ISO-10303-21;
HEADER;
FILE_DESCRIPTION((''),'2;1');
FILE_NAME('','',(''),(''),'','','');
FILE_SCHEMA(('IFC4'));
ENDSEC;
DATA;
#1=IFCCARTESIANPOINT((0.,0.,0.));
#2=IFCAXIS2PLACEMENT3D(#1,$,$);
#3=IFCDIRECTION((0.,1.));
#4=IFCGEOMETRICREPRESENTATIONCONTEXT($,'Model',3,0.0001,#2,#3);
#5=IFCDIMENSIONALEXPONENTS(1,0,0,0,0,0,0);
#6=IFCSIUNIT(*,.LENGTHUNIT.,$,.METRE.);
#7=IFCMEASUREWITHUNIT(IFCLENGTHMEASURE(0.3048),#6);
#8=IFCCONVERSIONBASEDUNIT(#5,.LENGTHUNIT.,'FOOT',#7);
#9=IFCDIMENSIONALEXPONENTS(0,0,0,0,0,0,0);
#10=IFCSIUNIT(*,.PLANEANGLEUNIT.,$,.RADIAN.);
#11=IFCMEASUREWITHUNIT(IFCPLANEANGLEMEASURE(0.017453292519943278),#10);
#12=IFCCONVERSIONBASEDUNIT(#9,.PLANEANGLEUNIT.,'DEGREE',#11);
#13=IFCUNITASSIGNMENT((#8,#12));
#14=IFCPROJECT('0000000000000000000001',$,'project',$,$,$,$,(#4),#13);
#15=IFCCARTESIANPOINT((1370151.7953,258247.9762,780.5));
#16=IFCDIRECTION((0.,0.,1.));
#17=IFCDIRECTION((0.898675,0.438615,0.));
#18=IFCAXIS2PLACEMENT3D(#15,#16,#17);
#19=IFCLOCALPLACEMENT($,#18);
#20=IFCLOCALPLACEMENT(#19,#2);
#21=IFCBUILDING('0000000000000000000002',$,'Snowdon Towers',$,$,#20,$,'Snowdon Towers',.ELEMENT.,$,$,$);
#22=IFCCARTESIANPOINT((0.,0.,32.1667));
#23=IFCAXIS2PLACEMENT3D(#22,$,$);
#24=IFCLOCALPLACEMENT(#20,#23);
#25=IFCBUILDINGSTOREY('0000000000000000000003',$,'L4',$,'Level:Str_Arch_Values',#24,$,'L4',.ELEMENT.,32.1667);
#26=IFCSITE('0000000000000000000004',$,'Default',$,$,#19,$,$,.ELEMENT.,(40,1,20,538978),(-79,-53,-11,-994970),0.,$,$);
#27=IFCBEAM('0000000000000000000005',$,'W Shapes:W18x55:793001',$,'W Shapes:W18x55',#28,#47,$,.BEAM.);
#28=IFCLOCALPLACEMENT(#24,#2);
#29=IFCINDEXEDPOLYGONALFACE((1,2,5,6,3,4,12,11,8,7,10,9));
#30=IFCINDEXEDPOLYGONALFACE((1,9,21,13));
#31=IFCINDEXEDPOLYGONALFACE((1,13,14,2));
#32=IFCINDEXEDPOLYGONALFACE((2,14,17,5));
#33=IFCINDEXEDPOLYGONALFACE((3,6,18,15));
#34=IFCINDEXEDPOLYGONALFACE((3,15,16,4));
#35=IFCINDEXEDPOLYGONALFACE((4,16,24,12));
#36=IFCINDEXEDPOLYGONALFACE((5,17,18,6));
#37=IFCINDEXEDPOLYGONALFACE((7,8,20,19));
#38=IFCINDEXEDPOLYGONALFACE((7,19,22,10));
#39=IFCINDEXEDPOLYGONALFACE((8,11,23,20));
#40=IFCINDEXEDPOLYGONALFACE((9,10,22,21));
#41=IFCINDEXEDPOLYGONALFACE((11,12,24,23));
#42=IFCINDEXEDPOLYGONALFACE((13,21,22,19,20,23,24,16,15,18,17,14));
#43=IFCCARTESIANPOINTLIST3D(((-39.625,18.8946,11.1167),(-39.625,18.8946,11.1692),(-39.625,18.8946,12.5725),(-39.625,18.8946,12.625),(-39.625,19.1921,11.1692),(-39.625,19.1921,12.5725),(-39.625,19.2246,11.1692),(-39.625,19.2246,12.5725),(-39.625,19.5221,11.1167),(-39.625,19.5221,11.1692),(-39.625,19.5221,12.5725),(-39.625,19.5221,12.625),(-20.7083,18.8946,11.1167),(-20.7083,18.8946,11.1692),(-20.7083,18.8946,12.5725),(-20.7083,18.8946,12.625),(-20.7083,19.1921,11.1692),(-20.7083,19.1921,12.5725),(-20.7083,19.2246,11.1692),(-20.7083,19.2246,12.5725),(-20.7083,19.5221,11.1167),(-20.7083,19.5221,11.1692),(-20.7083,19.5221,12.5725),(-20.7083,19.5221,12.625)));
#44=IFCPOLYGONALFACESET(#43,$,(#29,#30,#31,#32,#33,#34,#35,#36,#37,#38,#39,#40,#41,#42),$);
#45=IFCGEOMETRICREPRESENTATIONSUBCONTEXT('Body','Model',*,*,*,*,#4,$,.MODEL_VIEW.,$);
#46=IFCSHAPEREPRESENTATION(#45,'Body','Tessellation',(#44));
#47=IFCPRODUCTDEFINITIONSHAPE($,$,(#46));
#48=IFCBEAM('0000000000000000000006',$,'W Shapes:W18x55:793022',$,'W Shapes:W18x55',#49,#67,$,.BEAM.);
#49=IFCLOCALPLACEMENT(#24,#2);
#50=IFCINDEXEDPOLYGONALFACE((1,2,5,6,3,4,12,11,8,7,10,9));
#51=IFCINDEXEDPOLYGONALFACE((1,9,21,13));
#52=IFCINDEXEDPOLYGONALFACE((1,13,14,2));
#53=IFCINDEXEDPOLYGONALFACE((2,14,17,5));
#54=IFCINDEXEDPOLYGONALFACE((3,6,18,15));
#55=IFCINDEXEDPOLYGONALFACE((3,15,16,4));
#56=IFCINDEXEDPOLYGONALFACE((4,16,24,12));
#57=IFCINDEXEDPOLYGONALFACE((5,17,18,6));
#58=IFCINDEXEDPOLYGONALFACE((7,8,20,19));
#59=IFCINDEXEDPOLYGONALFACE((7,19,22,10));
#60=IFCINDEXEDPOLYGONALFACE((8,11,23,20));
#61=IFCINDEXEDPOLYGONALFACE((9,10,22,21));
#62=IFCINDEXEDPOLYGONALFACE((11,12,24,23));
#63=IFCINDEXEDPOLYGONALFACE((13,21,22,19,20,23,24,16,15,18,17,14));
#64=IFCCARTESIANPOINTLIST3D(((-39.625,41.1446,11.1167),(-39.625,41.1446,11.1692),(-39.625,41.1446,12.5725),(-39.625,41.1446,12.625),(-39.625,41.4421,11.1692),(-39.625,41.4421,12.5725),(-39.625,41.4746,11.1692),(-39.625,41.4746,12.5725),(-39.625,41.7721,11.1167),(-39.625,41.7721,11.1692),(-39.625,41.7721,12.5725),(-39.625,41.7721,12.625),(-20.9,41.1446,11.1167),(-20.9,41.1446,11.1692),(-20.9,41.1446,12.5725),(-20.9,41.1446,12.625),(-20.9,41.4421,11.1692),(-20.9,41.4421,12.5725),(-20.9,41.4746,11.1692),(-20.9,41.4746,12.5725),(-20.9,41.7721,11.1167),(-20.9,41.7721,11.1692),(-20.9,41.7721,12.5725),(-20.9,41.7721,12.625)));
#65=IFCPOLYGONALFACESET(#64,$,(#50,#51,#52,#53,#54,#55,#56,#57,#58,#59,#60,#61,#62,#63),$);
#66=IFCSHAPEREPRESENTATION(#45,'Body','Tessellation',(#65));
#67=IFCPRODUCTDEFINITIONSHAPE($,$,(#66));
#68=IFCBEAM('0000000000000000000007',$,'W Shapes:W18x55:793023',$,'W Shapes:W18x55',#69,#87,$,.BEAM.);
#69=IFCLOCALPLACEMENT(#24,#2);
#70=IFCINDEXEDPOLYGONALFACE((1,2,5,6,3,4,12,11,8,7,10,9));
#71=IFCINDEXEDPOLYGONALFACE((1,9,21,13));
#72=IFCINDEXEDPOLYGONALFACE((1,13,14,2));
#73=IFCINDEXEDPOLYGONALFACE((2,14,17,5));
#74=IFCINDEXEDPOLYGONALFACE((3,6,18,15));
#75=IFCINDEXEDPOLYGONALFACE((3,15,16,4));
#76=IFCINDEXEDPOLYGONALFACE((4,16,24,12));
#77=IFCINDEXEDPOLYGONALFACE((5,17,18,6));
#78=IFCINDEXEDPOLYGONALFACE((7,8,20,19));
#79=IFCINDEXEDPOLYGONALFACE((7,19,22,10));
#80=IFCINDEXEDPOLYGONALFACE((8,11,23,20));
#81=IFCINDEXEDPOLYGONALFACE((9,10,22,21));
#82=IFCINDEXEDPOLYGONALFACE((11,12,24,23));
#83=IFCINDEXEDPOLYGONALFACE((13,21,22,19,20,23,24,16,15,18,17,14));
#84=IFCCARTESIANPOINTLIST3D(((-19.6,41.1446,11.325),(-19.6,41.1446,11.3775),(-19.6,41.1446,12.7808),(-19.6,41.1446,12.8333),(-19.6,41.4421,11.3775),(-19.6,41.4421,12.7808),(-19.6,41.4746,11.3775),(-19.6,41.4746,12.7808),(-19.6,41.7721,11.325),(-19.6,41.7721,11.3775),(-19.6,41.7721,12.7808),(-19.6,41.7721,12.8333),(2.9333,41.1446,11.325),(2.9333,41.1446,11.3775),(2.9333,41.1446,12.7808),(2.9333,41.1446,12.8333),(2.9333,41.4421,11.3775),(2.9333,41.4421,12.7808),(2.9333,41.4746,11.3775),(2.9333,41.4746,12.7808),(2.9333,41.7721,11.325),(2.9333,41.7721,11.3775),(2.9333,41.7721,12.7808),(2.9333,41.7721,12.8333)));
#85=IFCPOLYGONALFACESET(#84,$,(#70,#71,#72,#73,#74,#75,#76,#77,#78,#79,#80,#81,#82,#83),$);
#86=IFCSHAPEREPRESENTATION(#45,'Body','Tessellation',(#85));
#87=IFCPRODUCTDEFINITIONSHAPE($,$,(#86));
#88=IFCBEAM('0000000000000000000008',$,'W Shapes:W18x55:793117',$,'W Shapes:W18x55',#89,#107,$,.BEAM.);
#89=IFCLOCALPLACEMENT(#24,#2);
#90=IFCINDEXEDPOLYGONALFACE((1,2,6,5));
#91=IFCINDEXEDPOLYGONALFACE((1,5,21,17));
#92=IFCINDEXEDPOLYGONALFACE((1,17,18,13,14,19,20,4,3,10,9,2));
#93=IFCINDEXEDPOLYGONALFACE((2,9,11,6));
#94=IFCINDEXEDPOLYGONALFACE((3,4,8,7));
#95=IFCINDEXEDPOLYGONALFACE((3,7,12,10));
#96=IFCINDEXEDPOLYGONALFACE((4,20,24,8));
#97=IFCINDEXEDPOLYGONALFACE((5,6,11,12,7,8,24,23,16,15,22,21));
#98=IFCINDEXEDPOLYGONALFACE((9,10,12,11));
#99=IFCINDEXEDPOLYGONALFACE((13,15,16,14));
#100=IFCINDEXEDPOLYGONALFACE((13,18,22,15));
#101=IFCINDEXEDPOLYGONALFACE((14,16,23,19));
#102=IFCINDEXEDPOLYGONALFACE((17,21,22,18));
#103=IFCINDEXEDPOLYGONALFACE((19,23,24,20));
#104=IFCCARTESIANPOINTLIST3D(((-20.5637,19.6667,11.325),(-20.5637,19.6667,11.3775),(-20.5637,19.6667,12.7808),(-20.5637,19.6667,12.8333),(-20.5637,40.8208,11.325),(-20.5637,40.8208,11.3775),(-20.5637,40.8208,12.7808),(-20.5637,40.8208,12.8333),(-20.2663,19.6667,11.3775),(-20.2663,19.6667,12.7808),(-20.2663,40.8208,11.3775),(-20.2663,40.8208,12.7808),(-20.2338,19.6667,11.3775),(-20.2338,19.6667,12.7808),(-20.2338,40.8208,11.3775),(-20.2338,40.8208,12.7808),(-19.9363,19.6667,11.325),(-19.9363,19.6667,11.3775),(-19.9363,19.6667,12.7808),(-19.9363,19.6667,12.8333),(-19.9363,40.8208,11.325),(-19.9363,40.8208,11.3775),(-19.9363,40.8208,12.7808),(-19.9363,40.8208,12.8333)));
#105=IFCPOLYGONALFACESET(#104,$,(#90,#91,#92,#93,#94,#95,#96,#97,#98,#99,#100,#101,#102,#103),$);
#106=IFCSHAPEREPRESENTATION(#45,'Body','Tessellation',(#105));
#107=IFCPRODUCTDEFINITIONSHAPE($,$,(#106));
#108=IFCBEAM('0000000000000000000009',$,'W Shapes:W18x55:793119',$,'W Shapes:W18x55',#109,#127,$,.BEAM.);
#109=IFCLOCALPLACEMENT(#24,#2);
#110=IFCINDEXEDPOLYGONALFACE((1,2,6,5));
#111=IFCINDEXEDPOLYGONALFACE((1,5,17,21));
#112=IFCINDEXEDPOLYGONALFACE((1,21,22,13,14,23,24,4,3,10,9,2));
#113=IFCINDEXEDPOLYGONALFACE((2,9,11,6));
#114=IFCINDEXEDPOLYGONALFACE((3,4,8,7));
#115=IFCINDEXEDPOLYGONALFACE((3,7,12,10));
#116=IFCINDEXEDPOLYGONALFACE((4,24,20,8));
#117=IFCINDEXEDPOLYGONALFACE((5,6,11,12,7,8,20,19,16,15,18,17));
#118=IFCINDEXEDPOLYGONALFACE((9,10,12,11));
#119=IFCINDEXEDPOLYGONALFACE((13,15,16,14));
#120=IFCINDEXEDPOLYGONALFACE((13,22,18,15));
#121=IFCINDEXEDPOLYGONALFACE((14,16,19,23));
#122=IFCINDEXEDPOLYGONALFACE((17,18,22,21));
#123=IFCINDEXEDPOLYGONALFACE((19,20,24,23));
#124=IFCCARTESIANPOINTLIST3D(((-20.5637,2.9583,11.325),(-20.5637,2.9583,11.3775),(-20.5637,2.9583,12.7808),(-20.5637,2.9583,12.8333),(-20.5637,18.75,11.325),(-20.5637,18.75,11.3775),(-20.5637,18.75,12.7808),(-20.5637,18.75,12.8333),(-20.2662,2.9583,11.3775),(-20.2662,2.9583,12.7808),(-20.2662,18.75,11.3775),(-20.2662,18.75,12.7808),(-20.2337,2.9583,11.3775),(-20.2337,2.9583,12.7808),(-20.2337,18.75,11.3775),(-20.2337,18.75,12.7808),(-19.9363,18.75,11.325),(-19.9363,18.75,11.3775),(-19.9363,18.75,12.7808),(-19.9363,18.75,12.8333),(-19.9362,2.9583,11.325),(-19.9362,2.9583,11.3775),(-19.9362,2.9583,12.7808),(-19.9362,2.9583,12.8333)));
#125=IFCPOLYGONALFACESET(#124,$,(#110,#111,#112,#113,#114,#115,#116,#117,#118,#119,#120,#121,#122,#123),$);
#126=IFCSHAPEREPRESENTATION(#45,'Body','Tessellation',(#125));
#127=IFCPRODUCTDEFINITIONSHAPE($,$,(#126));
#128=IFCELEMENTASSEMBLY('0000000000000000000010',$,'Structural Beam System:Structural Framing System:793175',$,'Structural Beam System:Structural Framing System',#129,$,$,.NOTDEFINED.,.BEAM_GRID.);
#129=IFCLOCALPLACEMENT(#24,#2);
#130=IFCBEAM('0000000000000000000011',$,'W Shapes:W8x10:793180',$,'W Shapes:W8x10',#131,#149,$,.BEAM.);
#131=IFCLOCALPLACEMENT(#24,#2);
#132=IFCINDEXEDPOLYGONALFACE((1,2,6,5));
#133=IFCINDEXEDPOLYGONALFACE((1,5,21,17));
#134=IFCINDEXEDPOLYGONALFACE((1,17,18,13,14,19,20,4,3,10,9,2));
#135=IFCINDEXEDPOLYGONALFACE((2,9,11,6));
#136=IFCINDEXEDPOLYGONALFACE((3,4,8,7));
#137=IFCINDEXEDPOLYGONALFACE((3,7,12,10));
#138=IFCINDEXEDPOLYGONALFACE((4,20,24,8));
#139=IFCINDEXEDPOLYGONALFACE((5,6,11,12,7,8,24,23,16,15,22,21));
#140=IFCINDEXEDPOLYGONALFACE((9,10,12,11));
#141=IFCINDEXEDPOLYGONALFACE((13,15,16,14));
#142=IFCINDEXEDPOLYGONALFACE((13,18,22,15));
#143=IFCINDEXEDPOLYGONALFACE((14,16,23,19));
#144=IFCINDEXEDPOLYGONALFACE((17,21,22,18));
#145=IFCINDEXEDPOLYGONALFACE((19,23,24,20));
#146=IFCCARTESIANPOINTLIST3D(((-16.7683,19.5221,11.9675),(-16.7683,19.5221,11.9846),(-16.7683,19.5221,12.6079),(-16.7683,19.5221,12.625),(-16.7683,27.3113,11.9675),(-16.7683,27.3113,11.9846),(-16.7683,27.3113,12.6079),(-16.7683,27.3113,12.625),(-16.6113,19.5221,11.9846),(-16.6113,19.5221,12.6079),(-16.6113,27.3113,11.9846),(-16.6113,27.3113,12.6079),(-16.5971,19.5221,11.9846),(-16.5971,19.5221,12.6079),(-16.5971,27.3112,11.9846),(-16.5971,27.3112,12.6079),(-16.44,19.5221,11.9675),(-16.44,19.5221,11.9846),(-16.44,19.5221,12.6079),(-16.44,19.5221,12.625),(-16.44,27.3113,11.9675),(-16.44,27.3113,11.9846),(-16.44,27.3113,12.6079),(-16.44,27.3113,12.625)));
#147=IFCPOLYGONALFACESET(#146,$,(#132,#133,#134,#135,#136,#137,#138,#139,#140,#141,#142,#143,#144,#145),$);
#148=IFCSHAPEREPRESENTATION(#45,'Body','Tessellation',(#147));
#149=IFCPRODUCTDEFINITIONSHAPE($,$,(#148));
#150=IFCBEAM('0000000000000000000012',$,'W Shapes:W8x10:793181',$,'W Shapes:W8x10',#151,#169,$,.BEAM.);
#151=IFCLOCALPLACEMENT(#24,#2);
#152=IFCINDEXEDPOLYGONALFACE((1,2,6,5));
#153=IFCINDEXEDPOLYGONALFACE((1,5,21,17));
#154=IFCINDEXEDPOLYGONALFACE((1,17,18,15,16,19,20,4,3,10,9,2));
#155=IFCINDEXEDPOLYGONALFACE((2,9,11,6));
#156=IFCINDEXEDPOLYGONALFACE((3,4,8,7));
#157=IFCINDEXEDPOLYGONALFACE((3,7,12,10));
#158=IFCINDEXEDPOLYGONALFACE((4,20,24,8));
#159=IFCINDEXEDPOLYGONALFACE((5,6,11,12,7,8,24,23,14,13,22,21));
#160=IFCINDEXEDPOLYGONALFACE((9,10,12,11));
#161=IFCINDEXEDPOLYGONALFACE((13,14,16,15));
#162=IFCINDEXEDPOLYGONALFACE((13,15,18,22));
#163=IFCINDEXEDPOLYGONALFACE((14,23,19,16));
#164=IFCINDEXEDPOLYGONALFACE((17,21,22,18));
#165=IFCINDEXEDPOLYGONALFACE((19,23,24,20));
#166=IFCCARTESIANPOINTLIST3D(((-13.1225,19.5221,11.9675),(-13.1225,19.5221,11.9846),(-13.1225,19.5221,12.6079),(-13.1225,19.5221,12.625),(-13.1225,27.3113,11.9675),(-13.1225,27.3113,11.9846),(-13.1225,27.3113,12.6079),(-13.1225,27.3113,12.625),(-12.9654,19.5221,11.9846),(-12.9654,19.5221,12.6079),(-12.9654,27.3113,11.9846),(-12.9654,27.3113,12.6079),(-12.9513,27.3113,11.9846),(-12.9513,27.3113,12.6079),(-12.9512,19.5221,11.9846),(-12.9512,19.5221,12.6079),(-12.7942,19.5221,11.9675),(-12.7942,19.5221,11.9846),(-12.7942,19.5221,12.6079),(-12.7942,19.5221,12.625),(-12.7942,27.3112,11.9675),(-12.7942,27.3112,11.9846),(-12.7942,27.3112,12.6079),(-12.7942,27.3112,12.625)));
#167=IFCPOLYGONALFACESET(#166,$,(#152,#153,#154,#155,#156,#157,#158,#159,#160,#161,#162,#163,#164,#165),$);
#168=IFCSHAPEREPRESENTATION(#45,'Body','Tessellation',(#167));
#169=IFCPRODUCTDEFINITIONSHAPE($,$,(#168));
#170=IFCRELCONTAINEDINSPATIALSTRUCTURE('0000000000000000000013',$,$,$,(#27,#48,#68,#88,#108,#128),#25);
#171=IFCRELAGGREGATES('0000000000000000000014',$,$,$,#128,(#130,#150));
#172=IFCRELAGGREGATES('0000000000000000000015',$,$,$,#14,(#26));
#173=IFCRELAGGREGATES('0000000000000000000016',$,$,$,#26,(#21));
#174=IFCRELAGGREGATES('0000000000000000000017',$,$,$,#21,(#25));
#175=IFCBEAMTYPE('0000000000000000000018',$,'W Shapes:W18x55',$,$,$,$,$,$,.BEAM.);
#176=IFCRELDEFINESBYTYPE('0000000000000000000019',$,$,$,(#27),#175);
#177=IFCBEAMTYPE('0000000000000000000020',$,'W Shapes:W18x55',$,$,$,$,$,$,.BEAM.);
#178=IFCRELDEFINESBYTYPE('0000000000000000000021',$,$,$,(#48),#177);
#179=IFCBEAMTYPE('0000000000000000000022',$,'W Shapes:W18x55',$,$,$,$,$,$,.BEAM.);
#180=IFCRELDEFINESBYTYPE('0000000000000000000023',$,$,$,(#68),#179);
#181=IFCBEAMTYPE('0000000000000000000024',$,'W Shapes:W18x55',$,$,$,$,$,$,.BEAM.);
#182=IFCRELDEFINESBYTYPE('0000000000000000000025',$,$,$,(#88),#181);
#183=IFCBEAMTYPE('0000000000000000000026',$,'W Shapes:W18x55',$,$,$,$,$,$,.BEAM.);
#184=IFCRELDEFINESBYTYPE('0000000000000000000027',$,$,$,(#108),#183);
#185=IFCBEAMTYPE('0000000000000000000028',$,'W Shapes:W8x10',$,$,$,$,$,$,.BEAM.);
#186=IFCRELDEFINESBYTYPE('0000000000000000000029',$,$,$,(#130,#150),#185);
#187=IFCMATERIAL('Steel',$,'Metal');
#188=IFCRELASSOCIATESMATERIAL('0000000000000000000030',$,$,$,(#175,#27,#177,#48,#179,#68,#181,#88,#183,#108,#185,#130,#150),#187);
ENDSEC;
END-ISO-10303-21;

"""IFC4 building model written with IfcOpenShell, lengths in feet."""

from ifc_helpers import new_model, entity, si_unit, converted_unit, direction, frame, origin, place, context, subcontext, project, spatial, indexed_curve, outline, extrude, source, transform, mapped, material, type_object, type_shapes, element, aggregate, save


model = new_model("IFC4")

# Units and contexts
model_context = context("Model", 3, precision=0.0001, world=origin(), true_north=direction((0.0, 1.0)))
body_context = subcontext(model_context, "Body", "Model", "MODEL_VIEW")
ifc_project = project(units=[converted_unit("LENGTHUNIT", "FOOT", entity("IfcLengthMeasure", 0.3048), si_unit("LENGTHUNIT", "METRE"), dimensions=[1, 0, 0, 0, 0, 0, 0]), converted_unit("PLANEANGLEUNIT", "DEGREE", entity("IfcPlaneAngleMeasure", 0.017453292519943278), si_unit("PLANEANGLEUNIT", "RADIAN"), dimensions=[0, 0, 0, 0, 0, 0, 0])], contexts=[model_context])

# Site, building, storey
site_placement = place(None, frame((1370151.7953, 258247.9762, 780.5), z_axis=(0.0, 0.0, 1.0), x_axis=(0.898675, 0.438615, 0.0)))
site = spatial("IfcSite", under=ifc_project, at=site_placement, Name="Default", CompositionType="ELEMENT", RefLatitude=(40, 1, 20, 538978), RefLongitude=(-79, -53, -11, -994970), RefElevation=0.0)
building_placement = place(site_placement, origin())
building = spatial("IfcBuilding", under=site, at=building_placement, Name="Snowdon Towers", LongName="Snowdon Towers", CompositionType="ELEMENT")
storey_placement = place(building_placement, frame((0.0, 0.0, 32.1667)))
storey = spatial("IfcBuildingStorey", under=building, at=storey_placement, Name="L4", ObjectType="Level:Str_Arch_Values", LongName="L4", CompositionType="ELEMENT", Elevation=32.1667)

# Shared definitions
ifc_material = material(Name="Steel", Category="Metal")

# Beams
beam_type_1 = type_object("IfcBeamType", Name="W Shapes:W18x55", PredefinedType="BEAM", material=ifc_material)
shared_shape_1 = source(origin(), body_context, "Body", "SweptSolid", [
    extrude(outline(indexed_curve([(-0.3138, -0.7017), (-0.3138, -0.7542), (0.3138, -0.7542), (0.3138, -0.7017), (0.0162, -0.7017), (0.0162, 0.7017), (0.3138, 0.7017), (0.3138, 0.7542), (-0.3137, 0.7542), (-0.3137, 0.7017), (-0.0163, 0.7017), (-0.0163, -0.7017), (-0.3138, -0.7017)], self_intersect=False)), frame((-9.5625, 0.0, 0.0), z_axis=(-1.0, 0.0, 0.0), x_axis=(0.0, -1.0, 0.0)), (0.0, 0.0, -1.0), 18.9167),
])
type_shapes(beam_type_1, [shared_shape_1])
beam_1_placement = place(storey_placement, frame((-30.0625, 19.2083, 11.8708)))
element("IfcBeam", 1, at=beam_1_placement, inside=storey, type_object=beam_type_1, material=ifc_material, Name="W Shapes:W18x55:793001", ObjectType="W Shapes:W18x55", PredefinedType="BEAM", context=body_context, shape_type="MappedRepresentation", body=[
    mapped(shared_shape_1, transform((0.0, 0.0, 0.0), scale=1.0)),
])
beam_type_2 = type_object("IfcBeamType", Name="W Shapes:W18x55", PredefinedType="BEAM", material=ifc_material)
shared_shape_2 = source(origin(), body_context, "Body", "SweptSolid", [
    extrude(outline(indexed_curve([(-0.3138, -0.7017), (-0.3138, -0.7542), (0.3138, -0.7542), (0.3138, -0.7017), (0.0162, -0.7017), (0.0162, 0.7017), (0.3138, 0.7017), (0.3138, 0.7542), (-0.3137, 0.7542), (-0.3137, 0.7017), (-0.0163, 0.7017), (-0.0163, -0.7017), (-0.3138, -0.7017)], self_intersect=False)), frame((-9.5625, 0.0, 0.0), z_axis=(-1.0, 0.0, 0.0), x_axis=(0.0, -1.0, 0.0)), (0.0, 0.0, -1.0), 18.725),
])
type_shapes(beam_type_2, [shared_shape_2])
beam_2_placement = place(storey_placement, frame((-30.0625, 41.4583, 11.8708)))
element("IfcBeam", 2, at=beam_2_placement, inside=storey, type_object=beam_type_2, material=ifc_material, Name="W Shapes:W18x55:793022", ObjectType="W Shapes:W18x55", PredefinedType="BEAM", context=body_context, shape_type="MappedRepresentation", body=[
    mapped(shared_shape_2, transform((0.0, 0.0, 0.0), scale=1.0)),
])
beam_type_3 = type_object("IfcBeamType", Name="W Shapes:W18x55", PredefinedType="BEAM", material=ifc_material)
shared_shape_3 = source(origin(), body_context, "Body", "SweptSolid", [
    extrude(outline(indexed_curve([(-0.3138, -0.7017), (-0.3138, -0.7542), (0.3138, -0.7542), (0.3138, -0.7017), (0.0162, -0.7017), (0.0162, 0.7017), (0.3138, 0.7017), (0.3138, 0.7542), (-0.3137, 0.7542), (-0.3137, 0.7017), (-0.0163, 0.7017), (-0.0163, -0.7017), (-0.3138, -0.7017)], self_intersect=False)), frame((-11.35, 0.0, 0.0), z_axis=(-1.0, 0.0, 0.0), x_axis=(0.0, -1.0, 0.0)), (0.0, 0.0, -1.0), 22.5333),
])
type_shapes(beam_type_3, [shared_shape_3])
beam_3_placement = place(storey_placement, frame((-8.25, 41.4583, 12.0792)))
element("IfcBeam", 3, at=beam_3_placement, inside=storey, type_object=beam_type_3, material=ifc_material, Name="W Shapes:W18x55:793023", ObjectType="W Shapes:W18x55", PredefinedType="BEAM", context=body_context, shape_type="MappedRepresentation", body=[
    mapped(shared_shape_3, transform((0.0, 0.0, 0.0), scale=1.0)),
])
beam_type_4 = type_object("IfcBeamType", Name="W Shapes:W18x55", PredefinedType="BEAM", material=ifc_material)
shared_shape_4 = source(origin(), body_context, "Body", "SweptSolid", [
    extrude(outline(indexed_curve([(-0.3138, -0.7017), (-0.3138, -0.7542), (0.3138, -0.7542), (0.3138, -0.7017), (0.0162, -0.7017), (0.0162, 0.7017), (0.3138, 0.7017), (0.3138, 0.7542), (-0.3137, 0.7542), (-0.3137, 0.7017), (-0.0163, 0.7017), (-0.0163, -0.7017), (-0.3138, -0.7017)], self_intersect=False)), frame((-10.4042, 0.0, 0.0), z_axis=(-1.0, 0.0, 0.0), x_axis=(0.0, -1.0, 0.0)), (0.0, 0.0, -1.0), 21.1542),
])
type_shapes(beam_type_4, [shared_shape_4])
beam_4_placement = place(storey_placement, frame((-20.25, 30.4167, 12.0792), z_axis=(0.0, 0.0, 1.0), x_axis=(0.0, -1.0, 0.0)))
element("IfcBeam", 4, at=beam_4_placement, inside=storey, type_object=beam_type_4, material=ifc_material, Name="W Shapes:W18x55:793117", ObjectType="W Shapes:W18x55", PredefinedType="BEAM", context=body_context, shape_type="MappedRepresentation", body=[
    mapped(shared_shape_4, transform((0.0, 0.0, 0.0), scale=1.0)),
])
beam_type_5 = type_object("IfcBeamType", Name="W Shapes:W18x55", PredefinedType="BEAM", material=ifc_material)
shared_shape_5 = source(origin(), body_context, "Body", "SweptSolid", [
    extrude(outline(indexed_curve([(-0.3138, -0.7017), (-0.3138, -0.7542), (0.3138, -0.7542), (0.3138, -0.7017), (0.0162, -0.7017), (0.0162, 0.7017), (0.3138, 0.7017), (0.3138, 0.7542), (-0.3137, 0.7542), (-0.3137, 0.7017), (-0.0163, 0.7017), (-0.0163, -0.7017), (-0.3138, -0.7017)], self_intersect=False)), frame((-7.8958, 0.0, 0.0), z_axis=(-1.0, 0.0, 0.0), x_axis=(0.0, -1.0, 0.0)), (0.0, 0.0, -1.0), 15.7917),
])
type_shapes(beam_type_5, [shared_shape_5])
beam_5_placement = place(storey_placement, frame((-20.25, 10.8542, 12.0792), z_axis=(0.0, 0.0, 1.0), x_axis=(0.0, -1.0, 0.0)))
element("IfcBeam", 5, at=beam_5_placement, inside=storey, type_object=beam_type_5, material=ifc_material, Name="W Shapes:W18x55:793119", ObjectType="W Shapes:W18x55", PredefinedType="BEAM", context=body_context, shape_type="MappedRepresentation", body=[
    mapped(shared_shape_5, transform((0.0, 0.0, 0.0), scale=1.0)),
])

# Element assembly, beams
assembly_1_placement = place(storey_placement, origin())
assembly_1 = element("IfcElementAssembly", 6, at=assembly_1_placement, inside=storey, Name="Structural Beam System:Structural Framing System:793175", ObjectType="Structural Beam System:Structural Framing System", AssemblyPlace="NOTDEFINED", PredefinedType="BEAM_GRID")
beam_type_6 = type_object("IfcBeamType", Name="W Shapes:W8x10", PredefinedType="BEAM", material=ifc_material)
shared_shape_6 = source(origin(), body_context, "Body", "SweptSolid", [
    extrude(outline(indexed_curve([(-0.1642, -0.3117), (-0.1642, -0.3288), (0.1642, -0.3288), (0.1642, -0.3117), (0.0071, -0.3117), (0.0071, 0.3117), (0.1642, 0.3117), (0.1642, 0.3287), (-0.1642, 0.3287), (-0.1642, 0.3117), (-0.0071, 0.3117), (-0.0071, -0.3117), (-0.1642, -0.3117)], self_intersect=False)), frame((-3.8946, 0.0, 0.0), z_axis=(-1.0, 0.0, 0.0), x_axis=(0.0, -1.0, 0.0)), (0.0, 0.0, -1.0), 7.7892),
])
type_shapes(beam_type_6, [shared_shape_6])
beam_6_placement = place(assembly_1_placement, frame((-16.6042, 23.4167, 12.2963), z_axis=(0.0, 0.0, 1.0), x_axis=(0.0, 1.0, 0.0)))
beam_6 = element("IfcBeam", 7, at=beam_6_placement, type_object=beam_type_6, material=ifc_material, Name="W Shapes:W8x10:793180", ObjectType="W Shapes:W8x10", PredefinedType="BEAM", context=body_context, shape_type="MappedRepresentation", body=[
    mapped(shared_shape_6, transform((0.0, 0.0, 0.0), scale=1.0)),
])
beam_7_placement = place(assembly_1_placement, frame((-12.9583, 23.4167, 12.2963), z_axis=(0.0, 0.0, 1.0), x_axis=(0.0, 1.0, 0.0)))
beam_7 = element("IfcBeam", 8, at=beam_7_placement, type_object=beam_type_6, material=ifc_material, Name="W Shapes:W8x10:793181", ObjectType="W Shapes:W8x10", PredefinedType="BEAM", context=body_context, shape_type="MappedRepresentation", body=[
    mapped(shared_shape_6, transform((0.0, 0.0, 0.0), scale=1.0)),
])
aggregate(assembly_1, [beam_6, beam_7])

save(model, "model.ifc")
